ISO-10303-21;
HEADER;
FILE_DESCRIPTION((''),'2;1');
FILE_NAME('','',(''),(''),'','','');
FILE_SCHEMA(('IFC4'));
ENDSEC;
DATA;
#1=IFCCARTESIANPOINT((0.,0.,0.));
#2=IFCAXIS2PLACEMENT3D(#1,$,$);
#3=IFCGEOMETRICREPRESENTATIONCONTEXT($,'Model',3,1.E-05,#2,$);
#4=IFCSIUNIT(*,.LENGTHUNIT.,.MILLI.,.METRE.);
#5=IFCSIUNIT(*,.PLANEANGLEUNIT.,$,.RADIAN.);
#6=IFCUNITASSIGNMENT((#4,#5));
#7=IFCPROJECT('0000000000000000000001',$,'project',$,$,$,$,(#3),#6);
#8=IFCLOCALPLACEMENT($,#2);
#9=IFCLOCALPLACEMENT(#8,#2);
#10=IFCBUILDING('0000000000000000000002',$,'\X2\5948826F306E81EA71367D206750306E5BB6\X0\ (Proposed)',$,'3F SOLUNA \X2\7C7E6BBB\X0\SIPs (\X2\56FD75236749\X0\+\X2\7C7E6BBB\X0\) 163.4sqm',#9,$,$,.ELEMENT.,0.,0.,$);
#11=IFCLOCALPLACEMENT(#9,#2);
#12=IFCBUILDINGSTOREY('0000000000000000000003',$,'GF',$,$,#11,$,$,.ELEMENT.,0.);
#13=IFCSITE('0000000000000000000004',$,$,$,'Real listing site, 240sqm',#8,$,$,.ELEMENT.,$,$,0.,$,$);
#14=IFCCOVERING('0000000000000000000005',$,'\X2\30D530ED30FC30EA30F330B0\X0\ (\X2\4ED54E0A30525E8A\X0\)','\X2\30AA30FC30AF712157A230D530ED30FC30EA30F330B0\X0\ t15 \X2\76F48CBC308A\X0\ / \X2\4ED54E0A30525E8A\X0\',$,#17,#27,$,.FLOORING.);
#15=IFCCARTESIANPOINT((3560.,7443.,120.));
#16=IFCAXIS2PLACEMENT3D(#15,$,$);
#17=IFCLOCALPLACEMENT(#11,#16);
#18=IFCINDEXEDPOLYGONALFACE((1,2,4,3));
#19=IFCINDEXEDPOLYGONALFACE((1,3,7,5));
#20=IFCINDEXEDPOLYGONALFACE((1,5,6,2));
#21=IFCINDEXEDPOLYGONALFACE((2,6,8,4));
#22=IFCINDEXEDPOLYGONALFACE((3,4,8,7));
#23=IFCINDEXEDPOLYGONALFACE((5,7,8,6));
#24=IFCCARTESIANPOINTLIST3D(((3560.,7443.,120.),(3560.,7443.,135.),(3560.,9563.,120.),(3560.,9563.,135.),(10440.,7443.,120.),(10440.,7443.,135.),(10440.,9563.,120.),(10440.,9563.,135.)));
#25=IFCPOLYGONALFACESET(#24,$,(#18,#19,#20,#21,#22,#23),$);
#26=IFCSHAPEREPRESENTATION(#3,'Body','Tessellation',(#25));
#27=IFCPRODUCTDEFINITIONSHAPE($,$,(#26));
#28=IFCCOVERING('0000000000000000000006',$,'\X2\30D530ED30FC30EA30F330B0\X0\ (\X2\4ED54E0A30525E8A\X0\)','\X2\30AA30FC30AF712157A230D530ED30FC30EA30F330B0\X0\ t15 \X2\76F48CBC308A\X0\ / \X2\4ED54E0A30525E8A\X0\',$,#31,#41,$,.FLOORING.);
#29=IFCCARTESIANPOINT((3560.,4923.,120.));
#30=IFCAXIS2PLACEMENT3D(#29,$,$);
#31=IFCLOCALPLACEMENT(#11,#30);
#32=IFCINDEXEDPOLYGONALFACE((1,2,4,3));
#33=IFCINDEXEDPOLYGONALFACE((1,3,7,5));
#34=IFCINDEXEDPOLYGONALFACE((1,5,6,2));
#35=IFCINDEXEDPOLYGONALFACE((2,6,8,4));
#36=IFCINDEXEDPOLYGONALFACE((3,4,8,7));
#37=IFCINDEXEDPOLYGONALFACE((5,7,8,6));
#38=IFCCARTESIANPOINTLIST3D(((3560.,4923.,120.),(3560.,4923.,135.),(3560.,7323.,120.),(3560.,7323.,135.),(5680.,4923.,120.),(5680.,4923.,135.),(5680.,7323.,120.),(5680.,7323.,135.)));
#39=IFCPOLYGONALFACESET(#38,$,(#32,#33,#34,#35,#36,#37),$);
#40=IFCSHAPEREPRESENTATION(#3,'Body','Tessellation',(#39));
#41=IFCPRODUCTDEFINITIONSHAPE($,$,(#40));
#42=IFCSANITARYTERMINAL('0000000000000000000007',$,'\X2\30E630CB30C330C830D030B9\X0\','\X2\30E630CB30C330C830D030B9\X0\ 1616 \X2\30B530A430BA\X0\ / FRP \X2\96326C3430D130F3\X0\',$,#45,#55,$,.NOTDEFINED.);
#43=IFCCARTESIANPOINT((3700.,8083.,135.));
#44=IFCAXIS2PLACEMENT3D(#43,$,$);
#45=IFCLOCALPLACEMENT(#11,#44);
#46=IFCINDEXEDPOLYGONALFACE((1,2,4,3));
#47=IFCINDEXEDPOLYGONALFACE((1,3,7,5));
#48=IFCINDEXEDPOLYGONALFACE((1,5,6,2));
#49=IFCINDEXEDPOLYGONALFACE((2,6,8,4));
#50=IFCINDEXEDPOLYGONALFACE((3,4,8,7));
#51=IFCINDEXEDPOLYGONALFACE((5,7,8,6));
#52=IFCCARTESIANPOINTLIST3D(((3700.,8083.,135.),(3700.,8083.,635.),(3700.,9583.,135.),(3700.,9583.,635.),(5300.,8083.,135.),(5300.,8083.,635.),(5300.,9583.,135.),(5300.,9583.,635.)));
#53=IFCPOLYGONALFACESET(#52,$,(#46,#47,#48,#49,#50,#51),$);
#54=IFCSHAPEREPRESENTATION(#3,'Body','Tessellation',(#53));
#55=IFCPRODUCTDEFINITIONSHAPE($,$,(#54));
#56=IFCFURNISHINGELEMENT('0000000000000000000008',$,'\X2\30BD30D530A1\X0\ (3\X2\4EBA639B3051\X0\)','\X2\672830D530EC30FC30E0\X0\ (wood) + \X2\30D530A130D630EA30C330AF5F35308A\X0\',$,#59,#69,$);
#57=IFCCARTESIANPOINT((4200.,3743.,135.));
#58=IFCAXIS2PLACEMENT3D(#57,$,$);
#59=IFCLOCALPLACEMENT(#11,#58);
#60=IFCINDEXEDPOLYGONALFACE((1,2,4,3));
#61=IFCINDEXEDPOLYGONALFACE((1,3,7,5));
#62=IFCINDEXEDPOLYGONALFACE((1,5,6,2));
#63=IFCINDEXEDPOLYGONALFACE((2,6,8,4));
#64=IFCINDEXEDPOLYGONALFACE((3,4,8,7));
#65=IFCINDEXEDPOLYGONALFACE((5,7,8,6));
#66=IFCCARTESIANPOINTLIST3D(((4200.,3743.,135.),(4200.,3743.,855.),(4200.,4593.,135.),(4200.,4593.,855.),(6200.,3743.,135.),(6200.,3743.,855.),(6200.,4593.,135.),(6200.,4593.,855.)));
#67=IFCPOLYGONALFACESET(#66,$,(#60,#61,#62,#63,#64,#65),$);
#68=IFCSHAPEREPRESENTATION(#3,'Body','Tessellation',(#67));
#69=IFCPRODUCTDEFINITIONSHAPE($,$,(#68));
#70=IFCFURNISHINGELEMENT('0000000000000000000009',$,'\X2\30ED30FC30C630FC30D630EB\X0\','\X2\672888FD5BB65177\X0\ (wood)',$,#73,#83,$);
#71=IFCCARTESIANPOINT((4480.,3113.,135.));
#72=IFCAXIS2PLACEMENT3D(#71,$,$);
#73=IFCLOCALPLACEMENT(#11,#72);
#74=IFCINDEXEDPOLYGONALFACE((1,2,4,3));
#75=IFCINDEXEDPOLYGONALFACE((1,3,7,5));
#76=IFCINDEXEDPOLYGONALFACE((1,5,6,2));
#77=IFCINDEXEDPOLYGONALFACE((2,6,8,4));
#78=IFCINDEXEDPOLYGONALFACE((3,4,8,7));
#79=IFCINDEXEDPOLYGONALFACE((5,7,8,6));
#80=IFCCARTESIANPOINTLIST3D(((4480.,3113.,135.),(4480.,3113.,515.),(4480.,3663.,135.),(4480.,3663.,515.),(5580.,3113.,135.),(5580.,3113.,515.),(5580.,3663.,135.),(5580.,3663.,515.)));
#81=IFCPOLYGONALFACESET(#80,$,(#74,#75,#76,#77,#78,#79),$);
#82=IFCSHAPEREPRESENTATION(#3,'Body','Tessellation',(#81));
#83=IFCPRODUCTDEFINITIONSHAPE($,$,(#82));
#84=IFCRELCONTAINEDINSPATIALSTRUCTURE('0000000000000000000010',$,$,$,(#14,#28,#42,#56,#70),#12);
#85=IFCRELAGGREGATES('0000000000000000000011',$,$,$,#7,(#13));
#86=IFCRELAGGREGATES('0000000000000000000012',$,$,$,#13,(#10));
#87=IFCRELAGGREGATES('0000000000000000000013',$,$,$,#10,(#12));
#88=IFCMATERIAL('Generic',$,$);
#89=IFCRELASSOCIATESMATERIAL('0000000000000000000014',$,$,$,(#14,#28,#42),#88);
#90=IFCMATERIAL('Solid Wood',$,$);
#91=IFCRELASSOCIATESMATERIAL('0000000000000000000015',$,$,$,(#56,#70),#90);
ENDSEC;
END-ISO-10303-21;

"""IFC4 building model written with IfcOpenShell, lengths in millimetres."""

from ifc_helpers import new_model, si_unit, frame, frame_2d, origin, place, context, project, spatial, rectangle, extrude, material, element, save


model = new_model("IFC4")

# Units and contexts
model_context = context("Model", 3, precision=1e-05, world=origin())
ifc_project = project(units=[si_unit("LENGTHUNIT", "METRE", prefix="MILLI"), si_unit("PLANEANGLEUNIT", "RADIAN")], contexts=[model_context])

# Site, building, storey
site_placement = place(None, origin())
site = spatial("IfcSite", under=ifc_project, at=site_placement, ObjectType="Real listing site, 240sqm", CompositionType="ELEMENT", RefElevation=0.0)
building_placement = place(site_placement, origin())
building = spatial("IfcBuilding", under=site, at=building_placement, Name="奈良の自然素材の家 (Proposed)", ObjectType="3F SOLUNA 籾殻SIPs (国産杉+籾殻) 163.4sqm", CompositionType="ELEMENT", ElevationOfRefHeight=0.0, ElevationOfTerrain=0.0)
storey_placement = place(building_placement, origin())
storey = spatial("IfcBuildingStorey", under=building, at=storey_placement, Name="GF", CompositionType="ELEMENT", Elevation=0.0)

# Shared definitions
ifc_material_1 = material(Name="Solid Wood")

# Coverings
ifc_material_2 = material(Name="Generic")
covering_1_placement = place(storey_placement, frame((3560.0, 7443.0, 120.0)))
element("IfcCovering", 1, at=covering_1_placement, inside=storey, material=ifc_material_2, Name="フローリング (仕上げ床)", Description="オーク無垢フローリング t15 直貼り / 仕上げ床", PredefinedType="FLOORING", context=model_context, shape_type="SweptSolid", body=[
    extrude(rectangle(XDim=6880.0, YDim=2120.0, at=frame_2d((3440.0, 1060.0))), frame((3560.0, 7443.0, 120.0)), (0.0, 0.0, 1.0), 15.0),
])
covering_2_placement = place(storey_placement, frame((3560.0, 4923.0, 120.0)))
element("IfcCovering", 2, at=covering_2_placement, inside=storey, material=ifc_material_2, Name="フローリング (仕上げ床)", Description="オーク無垢フローリング t15 直貼り / 仕上げ床", PredefinedType="FLOORING", context=model_context, shape_type="SweptSolid", body=[
    extrude(rectangle(XDim=2120.0, YDim=2400.0, at=frame_2d((1060.0, 1200.0))), frame((3560.0, 4923.0, 120.0)), (0.0, 0.0, 1.0), 15.0),
])

# Sanitary terminal
sanitary_terminal_placement = place(storey_placement, frame((3700.0, 8083.0, 135.0)))
element("IfcSanitaryTerminal", 3, at=sanitary_terminal_placement, inside=storey, material=ifc_material_2, Name="ユニットバス", Description="ユニットバス 1616 サイズ / FRP 防水パン", PredefinedType="NOTDEFINED", context=model_context, shape_type="SweptSolid", body=[
    extrude(rectangle(XDim=1600.0, YDim=1500.0, at=frame_2d((800.0, 750.0))), frame((3700.0, 8083.0, 135.0)), (0.0, 0.0, 1.0), 500.0),
])

# Furnishing elements
furnishing_1_placement = place(storey_placement, frame((4200.0, 3743.0, 135.0)))
element("IfcFurnishingElement", 4, at=furnishing_1_placement, inside=storey, material=ifc_material_1, Name="ソファ (3人掛け)", Description="木フレーム (wood) + ファブリック張り", context=model_context, shape_type="SweptSolid", body=[
    extrude(rectangle(XDim=2000.0, YDim=850.0, at=frame_2d((1000.0, 425.0))), frame((4200.0, 3743.0, 135.0)), (0.0, 0.0, 1.0), 720.0),
])
furnishing_2_placement = place(storey_placement, frame((4480.0, 3113.0, 135.0)))
element("IfcFurnishingElement", 5, at=furnishing_2_placement, inside=storey, material=ifc_material_1, Name="ローテーブル", Description="木製家具 (wood)", context=model_context, shape_type="SweptSolid", body=[
    extrude(rectangle(XDim=1100.0, YDim=550.0, at=frame_2d((550.0, 275.0))), frame((4480.0, 3113.0, 135.0)), (0.0, 0.0, 1.0), 380.0),
])

save(model, "model.ifc")
